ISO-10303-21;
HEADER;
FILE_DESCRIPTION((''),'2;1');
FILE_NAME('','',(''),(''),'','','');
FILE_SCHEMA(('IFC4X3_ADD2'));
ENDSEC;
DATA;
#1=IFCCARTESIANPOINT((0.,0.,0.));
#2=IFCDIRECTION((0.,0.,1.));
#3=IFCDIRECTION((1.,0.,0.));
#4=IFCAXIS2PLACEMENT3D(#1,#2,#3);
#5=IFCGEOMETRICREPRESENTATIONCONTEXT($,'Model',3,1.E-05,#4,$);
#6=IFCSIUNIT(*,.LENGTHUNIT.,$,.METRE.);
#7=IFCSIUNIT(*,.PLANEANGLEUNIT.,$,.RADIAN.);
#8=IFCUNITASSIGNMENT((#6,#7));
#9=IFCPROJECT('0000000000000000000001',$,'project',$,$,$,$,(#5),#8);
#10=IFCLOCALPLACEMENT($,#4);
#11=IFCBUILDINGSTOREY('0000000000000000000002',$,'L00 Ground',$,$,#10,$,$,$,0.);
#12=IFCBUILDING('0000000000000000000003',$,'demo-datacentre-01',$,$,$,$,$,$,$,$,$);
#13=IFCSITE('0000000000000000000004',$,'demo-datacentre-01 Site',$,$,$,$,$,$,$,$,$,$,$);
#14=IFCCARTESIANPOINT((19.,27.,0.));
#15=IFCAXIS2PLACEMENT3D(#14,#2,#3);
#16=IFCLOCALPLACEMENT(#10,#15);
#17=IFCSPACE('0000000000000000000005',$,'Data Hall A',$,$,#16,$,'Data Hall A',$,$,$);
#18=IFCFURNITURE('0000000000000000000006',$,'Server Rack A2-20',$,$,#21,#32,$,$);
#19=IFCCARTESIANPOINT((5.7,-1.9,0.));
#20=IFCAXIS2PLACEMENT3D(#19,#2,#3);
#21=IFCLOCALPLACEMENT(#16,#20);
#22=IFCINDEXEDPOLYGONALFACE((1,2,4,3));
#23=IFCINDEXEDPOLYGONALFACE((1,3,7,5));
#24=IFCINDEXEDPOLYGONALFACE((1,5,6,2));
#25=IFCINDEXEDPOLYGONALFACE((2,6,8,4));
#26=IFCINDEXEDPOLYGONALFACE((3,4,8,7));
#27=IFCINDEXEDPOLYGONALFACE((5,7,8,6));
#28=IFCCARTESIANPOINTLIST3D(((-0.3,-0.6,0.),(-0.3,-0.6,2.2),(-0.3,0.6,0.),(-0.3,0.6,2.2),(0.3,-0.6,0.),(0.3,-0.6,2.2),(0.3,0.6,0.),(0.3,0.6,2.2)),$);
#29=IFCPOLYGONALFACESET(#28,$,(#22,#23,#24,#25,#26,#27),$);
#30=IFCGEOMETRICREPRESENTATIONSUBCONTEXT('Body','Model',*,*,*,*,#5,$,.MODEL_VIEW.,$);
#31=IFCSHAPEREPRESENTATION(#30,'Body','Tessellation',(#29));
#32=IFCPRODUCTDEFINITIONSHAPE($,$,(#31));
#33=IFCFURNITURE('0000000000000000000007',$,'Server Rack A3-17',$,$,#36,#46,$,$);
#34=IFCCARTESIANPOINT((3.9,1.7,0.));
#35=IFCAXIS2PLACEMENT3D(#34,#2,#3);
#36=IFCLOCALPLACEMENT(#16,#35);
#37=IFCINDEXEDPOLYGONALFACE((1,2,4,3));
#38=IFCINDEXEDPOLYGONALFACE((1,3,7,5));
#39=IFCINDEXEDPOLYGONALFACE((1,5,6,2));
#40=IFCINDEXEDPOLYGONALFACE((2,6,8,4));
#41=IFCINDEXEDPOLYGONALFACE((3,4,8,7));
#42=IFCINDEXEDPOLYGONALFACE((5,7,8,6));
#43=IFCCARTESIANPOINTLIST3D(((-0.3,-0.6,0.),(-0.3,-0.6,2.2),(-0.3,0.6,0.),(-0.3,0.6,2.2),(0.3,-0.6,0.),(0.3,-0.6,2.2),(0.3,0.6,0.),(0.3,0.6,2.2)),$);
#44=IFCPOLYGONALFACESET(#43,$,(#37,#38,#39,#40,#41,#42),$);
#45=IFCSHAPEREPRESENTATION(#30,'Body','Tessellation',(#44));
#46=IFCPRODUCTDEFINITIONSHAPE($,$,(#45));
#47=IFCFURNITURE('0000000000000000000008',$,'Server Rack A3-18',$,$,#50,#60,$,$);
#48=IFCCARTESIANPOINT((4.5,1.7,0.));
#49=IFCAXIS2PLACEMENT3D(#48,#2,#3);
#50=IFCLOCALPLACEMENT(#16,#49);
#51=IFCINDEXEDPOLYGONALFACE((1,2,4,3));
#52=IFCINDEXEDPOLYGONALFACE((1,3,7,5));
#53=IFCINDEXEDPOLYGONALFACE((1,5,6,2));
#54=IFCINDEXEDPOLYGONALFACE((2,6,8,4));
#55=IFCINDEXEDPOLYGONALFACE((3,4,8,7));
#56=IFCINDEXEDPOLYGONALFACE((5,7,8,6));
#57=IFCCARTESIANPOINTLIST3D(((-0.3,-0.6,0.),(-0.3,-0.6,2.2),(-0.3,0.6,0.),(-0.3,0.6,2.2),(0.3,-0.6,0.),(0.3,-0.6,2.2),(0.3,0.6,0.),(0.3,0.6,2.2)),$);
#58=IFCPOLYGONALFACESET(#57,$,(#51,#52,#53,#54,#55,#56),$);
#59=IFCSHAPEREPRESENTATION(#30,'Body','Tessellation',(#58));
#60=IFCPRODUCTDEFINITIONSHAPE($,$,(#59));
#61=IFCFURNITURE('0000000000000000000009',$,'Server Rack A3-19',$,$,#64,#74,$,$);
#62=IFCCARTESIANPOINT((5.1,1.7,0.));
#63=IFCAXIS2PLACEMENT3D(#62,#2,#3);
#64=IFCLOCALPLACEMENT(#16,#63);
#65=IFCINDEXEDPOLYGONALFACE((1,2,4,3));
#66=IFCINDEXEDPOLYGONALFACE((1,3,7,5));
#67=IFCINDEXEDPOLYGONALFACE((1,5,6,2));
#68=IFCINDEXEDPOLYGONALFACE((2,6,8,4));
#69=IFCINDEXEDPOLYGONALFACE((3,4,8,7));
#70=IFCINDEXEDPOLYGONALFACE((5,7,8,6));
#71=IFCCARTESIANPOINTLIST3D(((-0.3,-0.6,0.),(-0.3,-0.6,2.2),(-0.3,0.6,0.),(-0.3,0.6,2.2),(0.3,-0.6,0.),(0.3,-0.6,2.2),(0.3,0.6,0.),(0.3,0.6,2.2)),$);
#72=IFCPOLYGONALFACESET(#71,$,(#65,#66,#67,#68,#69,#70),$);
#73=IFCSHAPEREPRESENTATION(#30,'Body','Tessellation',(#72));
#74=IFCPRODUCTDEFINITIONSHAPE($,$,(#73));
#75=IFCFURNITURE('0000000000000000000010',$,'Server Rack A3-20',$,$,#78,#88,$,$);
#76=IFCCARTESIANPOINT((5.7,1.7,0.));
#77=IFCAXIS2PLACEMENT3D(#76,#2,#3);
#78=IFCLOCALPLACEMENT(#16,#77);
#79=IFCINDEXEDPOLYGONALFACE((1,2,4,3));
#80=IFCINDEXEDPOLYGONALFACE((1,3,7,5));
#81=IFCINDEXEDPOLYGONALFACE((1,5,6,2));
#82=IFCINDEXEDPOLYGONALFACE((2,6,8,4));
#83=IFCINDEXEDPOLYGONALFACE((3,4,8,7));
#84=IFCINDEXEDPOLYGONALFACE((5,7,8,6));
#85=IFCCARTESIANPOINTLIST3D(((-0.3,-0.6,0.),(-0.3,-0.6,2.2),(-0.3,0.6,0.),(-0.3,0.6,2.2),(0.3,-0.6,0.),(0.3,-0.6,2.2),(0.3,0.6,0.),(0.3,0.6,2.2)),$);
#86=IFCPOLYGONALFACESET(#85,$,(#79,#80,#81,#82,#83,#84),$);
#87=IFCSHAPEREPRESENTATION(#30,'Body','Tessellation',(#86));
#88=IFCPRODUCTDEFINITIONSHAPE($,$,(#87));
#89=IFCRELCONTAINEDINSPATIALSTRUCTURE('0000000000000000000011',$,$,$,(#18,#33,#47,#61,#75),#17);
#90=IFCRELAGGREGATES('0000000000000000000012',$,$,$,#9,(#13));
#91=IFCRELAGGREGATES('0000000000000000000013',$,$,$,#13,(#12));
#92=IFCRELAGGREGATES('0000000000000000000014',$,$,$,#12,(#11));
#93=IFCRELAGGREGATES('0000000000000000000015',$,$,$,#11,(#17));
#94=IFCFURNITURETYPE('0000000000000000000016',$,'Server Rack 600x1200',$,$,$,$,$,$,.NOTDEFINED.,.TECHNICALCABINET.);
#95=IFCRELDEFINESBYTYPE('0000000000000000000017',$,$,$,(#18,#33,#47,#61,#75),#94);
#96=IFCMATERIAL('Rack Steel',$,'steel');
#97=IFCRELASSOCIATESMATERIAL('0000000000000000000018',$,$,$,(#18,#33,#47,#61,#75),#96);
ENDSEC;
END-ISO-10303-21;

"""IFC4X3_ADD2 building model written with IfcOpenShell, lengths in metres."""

from ifc_helpers import new_model, si_unit, frame, origin_with_axes, place, context, subcontext, project, spatial, rectangle, extrude, material, type_object, element, save


model = new_model("IFC4X3_ADD2")

# Units and contexts
model_context = context("Model", 3, precision=1e-05, world=origin_with_axes())
body_context = subcontext(model_context, "Body", "Model", "MODEL_VIEW")
ifc_project = project(units=[si_unit("LENGTHUNIT", "METRE"), si_unit("PLANEANGLEUNIT", "RADIAN")], contexts=[model_context])

# Site, building, storey
site = spatial("IfcSite", under=ifc_project, Name="demo-datacentre-01 Site")
building = spatial("IfcBuilding", under=site, Name="demo-datacentre-01")
storey_placement = place(None, origin_with_axes())
storey = spatial("IfcBuildingStorey", under=building, at=storey_placement, Name="L00 Ground", Elevation=0.0)

# Shared definitions
space_placement = place(storey_placement, frame((19.0, 27.0, 0.0), z_axis=(0.0, 0.0, 1.0), x_axis=(1.0, 0.0, 0.0)))
space = spatial("IfcSpace", under=storey, at=space_placement, Name="Data Hall A", LongName="Data Hall A")

# Furniture
ifc_material_1 = material(Name="Rack Steel", Category="steel")
furniture_type = type_object("IfcFurnitureType", Name="Server Rack 600x1200", AssemblyPlace="NOTDEFINED", PredefinedType="TECHNICALCABINET")
for number, where, z_axis, x_axis, name in (
    (1, (5.7, -1.9, 0.0), (0.0, 0.0, 1.0), (1.0, 0.0, 0.0), "Server Rack A2-20"),
    (2, (3.9, 1.7, 0.0), (0.0, 0.0, 1.0), (1.0, 0.0, 0.0), "Server Rack A3-17"),
    (3, (4.5, 1.7, 0.0), (0.0, 0.0, 1.0), (1.0, 0.0, 0.0), "Server Rack A3-18"),
    (4, (5.1, 1.7, 0.0), (0.0, 0.0, 1.0), (1.0, 0.0, 0.0), "Server Rack A3-19"),
    (5, (5.7, 1.7, 0.0), (0.0, 0.0, 1.0), (1.0, 0.0, 0.0), "Server Rack A3-20"),
):
    element("IfcFurniture", number, at=place(space_placement, frame(where, z_axis=z_axis, x_axis=x_axis)), inside=space, type_object=furniture_type, material=ifc_material_1, Name=name, context=body_context, shape_type="SweptSolid", body=[
        extrude(rectangle(XDim=0.6, YDim=1.2), origin_with_axes(), (0.0, 0.0, 1.0), 2.2),
    ])

save(model, "model.ifc")
